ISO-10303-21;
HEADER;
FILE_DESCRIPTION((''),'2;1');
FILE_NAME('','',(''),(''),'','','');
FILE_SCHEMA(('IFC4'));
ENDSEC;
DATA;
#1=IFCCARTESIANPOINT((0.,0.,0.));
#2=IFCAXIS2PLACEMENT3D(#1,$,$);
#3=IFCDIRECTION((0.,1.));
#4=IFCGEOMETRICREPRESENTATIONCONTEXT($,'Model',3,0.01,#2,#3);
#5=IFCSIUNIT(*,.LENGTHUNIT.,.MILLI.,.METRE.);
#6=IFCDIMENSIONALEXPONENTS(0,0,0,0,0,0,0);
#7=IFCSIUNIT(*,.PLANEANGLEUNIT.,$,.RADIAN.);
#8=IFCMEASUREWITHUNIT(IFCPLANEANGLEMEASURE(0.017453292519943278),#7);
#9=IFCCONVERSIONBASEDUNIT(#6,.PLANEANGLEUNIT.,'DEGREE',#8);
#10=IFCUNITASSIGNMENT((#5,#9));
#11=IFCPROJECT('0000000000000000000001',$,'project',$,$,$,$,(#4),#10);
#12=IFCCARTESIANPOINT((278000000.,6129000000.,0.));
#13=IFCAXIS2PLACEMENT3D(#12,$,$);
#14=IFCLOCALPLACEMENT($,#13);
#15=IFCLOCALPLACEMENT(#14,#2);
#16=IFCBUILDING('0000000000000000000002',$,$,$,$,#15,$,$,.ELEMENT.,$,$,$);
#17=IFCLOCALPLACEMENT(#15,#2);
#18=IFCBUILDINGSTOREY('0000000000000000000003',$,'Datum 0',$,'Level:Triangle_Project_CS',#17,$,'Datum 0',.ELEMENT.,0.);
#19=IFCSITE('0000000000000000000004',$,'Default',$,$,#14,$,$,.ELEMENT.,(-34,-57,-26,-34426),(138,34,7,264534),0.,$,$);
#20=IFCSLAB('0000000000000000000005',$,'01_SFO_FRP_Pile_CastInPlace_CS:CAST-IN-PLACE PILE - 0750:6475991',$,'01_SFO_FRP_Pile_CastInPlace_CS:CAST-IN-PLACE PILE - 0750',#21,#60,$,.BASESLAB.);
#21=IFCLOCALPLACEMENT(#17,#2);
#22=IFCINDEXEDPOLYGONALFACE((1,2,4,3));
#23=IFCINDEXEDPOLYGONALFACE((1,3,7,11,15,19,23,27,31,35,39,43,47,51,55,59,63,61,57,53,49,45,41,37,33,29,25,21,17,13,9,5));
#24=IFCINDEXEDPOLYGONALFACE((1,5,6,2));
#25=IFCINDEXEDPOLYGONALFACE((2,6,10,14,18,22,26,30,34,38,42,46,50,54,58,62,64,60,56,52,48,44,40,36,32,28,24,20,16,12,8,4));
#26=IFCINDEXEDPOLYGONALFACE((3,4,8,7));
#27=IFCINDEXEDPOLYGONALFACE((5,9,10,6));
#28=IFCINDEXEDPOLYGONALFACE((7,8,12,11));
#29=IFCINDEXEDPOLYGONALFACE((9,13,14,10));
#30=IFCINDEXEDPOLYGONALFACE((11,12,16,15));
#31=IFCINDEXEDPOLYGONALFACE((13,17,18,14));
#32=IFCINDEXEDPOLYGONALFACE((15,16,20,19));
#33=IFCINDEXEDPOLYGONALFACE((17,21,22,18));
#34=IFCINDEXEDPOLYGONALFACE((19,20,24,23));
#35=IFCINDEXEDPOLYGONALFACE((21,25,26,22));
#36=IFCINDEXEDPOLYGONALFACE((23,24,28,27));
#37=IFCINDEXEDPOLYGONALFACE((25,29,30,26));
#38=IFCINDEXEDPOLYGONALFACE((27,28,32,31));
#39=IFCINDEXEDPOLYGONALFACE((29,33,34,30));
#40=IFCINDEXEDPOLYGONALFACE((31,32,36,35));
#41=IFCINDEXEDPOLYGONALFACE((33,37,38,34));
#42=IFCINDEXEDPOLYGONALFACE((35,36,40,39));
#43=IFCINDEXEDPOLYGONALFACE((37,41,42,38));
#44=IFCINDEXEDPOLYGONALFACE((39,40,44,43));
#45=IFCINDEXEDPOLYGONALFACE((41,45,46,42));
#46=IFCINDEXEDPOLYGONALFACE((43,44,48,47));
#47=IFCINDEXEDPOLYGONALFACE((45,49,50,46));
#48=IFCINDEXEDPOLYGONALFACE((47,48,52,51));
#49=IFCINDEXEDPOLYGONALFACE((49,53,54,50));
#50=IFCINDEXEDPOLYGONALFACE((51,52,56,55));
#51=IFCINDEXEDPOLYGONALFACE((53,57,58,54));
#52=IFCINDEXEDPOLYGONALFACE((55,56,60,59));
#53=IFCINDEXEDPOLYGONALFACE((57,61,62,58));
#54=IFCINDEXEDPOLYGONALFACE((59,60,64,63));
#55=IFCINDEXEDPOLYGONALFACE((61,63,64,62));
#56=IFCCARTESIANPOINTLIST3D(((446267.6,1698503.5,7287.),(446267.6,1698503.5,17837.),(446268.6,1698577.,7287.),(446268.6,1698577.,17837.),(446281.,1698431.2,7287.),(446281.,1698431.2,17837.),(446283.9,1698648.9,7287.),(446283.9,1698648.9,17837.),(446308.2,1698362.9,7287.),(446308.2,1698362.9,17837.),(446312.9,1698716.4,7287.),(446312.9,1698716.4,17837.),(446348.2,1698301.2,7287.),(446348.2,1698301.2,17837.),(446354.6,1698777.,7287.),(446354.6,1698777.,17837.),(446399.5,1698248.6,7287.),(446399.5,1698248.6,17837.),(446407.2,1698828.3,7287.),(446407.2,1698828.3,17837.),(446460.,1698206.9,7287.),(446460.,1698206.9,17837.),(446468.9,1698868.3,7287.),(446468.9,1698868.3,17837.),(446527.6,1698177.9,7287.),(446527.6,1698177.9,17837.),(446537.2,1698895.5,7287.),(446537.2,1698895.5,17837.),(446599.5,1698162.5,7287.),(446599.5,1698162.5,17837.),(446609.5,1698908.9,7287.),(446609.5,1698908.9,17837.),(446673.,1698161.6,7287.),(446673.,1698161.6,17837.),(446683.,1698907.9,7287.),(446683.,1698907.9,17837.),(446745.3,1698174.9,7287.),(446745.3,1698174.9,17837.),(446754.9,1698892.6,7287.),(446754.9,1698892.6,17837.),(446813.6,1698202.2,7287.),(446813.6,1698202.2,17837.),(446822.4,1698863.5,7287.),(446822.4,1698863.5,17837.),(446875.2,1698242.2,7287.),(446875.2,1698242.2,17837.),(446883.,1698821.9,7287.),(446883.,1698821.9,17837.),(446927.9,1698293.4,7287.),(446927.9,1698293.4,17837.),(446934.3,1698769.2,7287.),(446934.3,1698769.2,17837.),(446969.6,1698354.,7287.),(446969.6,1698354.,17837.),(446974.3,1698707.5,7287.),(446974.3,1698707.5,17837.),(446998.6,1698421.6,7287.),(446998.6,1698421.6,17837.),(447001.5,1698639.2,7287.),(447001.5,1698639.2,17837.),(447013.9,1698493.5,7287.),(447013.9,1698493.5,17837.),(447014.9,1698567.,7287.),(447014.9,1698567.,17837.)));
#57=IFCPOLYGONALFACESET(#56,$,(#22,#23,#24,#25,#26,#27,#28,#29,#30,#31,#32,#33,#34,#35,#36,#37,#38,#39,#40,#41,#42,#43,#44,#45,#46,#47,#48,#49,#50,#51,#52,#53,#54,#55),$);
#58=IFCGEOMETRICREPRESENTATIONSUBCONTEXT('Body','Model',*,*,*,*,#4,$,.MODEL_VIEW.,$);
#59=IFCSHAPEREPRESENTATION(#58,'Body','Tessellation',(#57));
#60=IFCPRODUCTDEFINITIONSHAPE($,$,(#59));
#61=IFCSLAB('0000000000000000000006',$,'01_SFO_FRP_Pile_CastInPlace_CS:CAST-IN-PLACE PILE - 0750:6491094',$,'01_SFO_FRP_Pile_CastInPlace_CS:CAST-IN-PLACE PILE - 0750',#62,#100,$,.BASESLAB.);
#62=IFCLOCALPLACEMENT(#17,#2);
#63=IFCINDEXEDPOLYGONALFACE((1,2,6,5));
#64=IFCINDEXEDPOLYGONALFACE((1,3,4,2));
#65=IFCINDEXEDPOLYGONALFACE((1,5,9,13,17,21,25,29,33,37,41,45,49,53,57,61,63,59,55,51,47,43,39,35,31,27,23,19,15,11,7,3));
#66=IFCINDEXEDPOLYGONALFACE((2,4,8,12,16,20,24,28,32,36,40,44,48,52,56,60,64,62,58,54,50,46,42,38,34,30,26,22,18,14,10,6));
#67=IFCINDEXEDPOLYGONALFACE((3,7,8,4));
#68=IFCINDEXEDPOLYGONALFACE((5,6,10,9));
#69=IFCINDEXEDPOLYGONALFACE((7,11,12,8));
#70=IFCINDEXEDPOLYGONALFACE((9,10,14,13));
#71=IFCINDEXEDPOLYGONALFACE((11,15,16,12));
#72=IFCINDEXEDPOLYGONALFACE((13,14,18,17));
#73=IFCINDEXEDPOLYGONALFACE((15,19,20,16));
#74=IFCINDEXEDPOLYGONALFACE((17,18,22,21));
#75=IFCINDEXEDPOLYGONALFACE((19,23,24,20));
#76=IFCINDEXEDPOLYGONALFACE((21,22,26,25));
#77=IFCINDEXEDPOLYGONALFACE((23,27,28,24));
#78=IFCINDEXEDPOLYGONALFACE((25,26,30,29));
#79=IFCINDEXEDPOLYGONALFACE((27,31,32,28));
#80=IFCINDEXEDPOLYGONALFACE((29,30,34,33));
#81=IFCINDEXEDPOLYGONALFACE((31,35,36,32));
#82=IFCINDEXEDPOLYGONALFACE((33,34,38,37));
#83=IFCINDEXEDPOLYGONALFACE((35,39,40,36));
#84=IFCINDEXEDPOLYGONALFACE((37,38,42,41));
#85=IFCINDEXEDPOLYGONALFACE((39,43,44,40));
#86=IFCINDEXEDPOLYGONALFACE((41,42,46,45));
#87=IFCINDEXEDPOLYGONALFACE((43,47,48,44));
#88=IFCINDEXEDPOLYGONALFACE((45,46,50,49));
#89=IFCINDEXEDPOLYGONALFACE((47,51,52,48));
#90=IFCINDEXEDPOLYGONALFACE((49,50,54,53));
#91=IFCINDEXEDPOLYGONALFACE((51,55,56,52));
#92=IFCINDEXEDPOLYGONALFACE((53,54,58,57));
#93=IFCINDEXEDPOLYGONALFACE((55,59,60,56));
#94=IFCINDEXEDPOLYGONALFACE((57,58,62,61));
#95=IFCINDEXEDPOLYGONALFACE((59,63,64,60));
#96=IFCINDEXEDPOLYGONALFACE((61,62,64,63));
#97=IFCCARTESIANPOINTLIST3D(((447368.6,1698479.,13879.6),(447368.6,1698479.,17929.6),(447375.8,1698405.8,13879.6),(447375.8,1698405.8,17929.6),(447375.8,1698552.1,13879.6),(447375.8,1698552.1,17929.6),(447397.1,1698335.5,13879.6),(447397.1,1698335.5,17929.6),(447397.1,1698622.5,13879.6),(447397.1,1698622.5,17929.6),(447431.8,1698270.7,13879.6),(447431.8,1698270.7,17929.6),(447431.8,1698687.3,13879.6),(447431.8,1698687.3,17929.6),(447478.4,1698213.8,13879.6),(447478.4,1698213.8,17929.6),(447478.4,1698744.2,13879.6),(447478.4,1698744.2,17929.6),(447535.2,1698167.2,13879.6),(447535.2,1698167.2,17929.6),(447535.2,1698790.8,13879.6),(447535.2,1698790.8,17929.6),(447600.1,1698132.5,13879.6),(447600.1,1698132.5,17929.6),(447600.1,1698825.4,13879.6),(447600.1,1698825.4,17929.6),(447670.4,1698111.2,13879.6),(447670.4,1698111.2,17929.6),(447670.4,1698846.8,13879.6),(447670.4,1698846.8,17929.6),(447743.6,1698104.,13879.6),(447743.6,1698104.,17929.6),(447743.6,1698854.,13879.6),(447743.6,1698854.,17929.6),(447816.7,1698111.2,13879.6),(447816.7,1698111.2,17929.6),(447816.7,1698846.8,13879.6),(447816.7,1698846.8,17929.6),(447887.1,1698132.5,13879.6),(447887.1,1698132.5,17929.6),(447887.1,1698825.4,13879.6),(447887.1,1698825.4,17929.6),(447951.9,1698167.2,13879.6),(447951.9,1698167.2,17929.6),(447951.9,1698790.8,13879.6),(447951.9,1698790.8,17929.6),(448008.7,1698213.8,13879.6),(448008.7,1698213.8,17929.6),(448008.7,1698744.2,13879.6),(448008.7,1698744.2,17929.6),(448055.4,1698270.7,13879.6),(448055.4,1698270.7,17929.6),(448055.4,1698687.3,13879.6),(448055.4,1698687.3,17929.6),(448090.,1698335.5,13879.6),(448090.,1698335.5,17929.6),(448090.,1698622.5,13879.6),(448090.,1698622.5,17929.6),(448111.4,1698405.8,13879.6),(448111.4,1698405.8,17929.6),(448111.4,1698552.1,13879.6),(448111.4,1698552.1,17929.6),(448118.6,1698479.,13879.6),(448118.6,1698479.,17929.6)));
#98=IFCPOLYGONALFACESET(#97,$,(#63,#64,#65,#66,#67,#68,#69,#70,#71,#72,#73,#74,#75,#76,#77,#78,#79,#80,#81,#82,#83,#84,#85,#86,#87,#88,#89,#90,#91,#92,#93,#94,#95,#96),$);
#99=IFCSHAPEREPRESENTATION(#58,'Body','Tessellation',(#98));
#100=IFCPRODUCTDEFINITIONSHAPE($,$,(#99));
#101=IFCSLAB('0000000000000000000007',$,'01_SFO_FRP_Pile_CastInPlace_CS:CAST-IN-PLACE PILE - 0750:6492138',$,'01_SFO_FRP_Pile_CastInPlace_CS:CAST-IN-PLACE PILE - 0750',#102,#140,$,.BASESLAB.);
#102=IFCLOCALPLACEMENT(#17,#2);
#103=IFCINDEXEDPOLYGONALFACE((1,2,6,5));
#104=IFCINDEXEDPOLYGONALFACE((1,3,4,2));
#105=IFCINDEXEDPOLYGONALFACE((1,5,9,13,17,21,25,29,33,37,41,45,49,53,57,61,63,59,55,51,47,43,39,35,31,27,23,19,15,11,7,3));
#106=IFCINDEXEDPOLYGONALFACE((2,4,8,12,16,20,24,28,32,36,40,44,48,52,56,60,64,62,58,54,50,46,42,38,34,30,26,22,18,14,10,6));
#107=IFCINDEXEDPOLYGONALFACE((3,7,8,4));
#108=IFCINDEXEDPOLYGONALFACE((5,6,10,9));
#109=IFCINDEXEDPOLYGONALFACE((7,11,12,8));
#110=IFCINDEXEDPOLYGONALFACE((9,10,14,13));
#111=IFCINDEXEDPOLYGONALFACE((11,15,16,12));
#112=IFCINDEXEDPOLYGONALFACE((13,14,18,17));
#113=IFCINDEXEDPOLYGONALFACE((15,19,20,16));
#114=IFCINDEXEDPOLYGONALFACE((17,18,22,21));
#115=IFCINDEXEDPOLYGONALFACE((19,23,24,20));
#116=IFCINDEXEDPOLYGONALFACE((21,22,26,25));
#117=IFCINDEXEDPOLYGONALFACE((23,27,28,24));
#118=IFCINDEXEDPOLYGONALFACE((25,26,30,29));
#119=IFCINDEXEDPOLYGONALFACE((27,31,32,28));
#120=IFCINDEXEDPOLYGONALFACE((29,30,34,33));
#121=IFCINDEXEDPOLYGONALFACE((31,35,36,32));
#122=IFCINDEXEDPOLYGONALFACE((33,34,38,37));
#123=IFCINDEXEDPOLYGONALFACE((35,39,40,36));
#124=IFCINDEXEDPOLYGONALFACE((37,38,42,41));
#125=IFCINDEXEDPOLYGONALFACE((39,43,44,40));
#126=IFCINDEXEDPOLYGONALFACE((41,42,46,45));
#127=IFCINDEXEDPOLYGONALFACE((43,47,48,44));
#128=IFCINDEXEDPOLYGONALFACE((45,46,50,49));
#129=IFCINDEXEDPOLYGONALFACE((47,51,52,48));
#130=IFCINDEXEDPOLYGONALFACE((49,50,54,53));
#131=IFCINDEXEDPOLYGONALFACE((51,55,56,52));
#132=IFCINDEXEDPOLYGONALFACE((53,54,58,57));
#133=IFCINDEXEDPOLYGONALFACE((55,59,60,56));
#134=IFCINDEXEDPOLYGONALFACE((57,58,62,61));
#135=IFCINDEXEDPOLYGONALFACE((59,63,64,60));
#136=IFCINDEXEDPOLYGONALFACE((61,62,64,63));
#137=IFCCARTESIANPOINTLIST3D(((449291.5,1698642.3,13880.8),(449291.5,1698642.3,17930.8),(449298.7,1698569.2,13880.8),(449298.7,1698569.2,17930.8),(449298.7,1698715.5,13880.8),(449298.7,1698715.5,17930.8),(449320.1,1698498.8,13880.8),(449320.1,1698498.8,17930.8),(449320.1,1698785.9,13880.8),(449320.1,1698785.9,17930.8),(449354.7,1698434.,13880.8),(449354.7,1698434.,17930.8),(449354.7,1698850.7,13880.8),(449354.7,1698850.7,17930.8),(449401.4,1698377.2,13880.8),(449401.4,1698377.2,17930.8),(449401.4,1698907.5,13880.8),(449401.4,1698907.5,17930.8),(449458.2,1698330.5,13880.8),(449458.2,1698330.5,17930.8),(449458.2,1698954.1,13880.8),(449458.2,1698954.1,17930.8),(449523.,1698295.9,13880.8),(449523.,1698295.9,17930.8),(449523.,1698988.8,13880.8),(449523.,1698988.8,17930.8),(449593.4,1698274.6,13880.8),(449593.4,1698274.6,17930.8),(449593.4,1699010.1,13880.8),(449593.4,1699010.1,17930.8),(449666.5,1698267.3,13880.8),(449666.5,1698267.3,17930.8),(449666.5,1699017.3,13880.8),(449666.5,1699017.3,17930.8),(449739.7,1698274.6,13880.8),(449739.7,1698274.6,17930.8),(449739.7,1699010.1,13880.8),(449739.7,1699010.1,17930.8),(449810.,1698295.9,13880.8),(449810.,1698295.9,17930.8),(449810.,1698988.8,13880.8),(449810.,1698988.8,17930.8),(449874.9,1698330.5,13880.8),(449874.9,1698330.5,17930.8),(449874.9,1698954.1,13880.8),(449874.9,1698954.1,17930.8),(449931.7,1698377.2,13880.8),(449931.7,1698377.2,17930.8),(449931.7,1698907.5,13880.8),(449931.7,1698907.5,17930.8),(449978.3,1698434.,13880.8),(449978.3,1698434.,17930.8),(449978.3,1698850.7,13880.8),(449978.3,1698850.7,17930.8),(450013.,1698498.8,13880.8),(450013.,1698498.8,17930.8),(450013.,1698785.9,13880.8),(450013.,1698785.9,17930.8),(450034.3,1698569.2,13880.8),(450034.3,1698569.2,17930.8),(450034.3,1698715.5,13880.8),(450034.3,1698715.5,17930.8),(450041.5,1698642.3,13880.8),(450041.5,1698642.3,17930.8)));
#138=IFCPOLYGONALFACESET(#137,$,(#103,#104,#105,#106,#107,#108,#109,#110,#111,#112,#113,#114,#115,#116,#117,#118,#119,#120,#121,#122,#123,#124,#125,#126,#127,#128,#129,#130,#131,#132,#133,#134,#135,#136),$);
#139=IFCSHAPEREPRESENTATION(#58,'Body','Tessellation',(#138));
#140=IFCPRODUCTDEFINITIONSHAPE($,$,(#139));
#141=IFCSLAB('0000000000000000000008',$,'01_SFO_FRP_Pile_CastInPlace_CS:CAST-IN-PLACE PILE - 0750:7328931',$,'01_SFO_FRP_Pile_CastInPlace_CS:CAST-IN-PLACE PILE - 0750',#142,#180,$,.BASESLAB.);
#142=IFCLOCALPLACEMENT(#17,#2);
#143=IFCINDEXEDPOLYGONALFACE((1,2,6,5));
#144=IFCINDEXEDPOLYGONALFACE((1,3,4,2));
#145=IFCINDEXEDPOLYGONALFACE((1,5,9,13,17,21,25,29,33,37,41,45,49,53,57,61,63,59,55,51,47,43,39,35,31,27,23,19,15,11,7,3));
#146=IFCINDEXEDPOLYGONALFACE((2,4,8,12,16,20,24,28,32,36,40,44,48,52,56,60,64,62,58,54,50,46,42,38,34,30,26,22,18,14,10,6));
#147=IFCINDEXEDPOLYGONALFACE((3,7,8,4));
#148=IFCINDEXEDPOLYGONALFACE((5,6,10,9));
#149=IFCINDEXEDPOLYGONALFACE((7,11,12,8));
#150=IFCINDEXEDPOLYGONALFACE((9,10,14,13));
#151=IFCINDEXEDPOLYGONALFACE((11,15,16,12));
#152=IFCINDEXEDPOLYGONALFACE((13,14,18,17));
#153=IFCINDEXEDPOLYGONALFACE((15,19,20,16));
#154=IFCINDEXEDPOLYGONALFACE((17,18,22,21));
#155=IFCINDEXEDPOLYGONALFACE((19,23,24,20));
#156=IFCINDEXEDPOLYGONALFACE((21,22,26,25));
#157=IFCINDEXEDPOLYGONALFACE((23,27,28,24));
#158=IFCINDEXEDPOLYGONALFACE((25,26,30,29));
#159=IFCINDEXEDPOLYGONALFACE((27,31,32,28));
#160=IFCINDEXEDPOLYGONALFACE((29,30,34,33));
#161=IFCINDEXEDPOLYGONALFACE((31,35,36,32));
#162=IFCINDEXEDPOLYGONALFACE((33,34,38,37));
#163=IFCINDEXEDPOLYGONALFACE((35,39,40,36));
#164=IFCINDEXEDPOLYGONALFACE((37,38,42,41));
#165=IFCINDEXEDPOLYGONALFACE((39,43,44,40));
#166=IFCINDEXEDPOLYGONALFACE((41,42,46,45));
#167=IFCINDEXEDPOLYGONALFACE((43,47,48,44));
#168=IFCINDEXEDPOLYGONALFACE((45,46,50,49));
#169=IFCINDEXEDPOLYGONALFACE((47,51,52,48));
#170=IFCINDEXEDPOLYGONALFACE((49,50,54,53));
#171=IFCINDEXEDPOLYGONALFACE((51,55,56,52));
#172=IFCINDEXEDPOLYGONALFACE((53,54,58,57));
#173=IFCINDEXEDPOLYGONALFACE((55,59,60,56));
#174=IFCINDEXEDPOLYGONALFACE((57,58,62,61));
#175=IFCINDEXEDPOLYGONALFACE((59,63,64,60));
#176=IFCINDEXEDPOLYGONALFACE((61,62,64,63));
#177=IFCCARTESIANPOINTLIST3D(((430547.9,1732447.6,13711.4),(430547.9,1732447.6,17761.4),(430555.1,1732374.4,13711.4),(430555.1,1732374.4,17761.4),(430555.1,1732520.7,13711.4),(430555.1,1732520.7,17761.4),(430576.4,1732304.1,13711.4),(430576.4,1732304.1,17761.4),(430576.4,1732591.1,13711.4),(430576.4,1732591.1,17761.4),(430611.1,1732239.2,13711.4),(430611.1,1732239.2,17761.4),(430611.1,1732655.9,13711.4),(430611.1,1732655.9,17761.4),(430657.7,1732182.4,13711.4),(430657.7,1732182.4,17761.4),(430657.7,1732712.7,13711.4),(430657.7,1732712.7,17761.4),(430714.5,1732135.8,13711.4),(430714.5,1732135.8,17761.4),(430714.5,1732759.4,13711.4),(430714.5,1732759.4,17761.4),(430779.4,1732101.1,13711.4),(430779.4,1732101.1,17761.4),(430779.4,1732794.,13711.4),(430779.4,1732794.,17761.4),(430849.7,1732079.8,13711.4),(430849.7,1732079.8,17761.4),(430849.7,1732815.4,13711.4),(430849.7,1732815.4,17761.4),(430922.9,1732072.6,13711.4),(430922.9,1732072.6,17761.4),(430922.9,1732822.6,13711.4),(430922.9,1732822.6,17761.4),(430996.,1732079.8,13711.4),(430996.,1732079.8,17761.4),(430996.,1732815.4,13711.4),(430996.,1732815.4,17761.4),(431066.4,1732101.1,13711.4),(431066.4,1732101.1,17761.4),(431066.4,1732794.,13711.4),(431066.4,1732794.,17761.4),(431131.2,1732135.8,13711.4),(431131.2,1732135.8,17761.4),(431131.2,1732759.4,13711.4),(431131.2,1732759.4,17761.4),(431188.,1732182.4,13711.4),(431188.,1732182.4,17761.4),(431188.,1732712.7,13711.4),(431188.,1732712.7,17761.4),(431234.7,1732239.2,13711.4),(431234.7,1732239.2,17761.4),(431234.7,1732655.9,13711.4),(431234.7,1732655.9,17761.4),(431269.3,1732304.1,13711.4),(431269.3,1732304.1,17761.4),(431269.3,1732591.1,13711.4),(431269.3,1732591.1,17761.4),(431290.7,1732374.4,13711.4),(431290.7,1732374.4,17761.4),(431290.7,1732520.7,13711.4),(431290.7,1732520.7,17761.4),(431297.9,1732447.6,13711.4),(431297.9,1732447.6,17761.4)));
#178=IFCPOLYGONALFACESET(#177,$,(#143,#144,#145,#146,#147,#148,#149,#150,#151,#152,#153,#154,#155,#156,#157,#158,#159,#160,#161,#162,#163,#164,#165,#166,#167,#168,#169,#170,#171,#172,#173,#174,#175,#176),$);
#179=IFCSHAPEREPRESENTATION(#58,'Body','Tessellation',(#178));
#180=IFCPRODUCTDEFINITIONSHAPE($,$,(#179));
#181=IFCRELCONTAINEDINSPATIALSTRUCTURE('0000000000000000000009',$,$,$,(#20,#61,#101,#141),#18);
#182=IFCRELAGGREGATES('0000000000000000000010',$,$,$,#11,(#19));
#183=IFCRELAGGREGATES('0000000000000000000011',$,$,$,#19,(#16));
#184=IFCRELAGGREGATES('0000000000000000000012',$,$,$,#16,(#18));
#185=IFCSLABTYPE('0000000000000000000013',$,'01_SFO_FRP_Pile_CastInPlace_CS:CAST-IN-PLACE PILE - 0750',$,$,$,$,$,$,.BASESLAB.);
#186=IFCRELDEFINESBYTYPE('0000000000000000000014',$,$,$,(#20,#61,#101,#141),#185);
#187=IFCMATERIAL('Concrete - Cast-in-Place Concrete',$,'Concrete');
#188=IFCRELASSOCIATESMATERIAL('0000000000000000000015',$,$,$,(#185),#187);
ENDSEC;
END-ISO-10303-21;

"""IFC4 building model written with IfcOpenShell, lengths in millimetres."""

from ifc_helpers import new_model, entity, si_unit, converted_unit, direction, frame, origin, place, context, subcontext, project, spatial, arc, indexed_curve, outline, extrude, material, type_object, element, save


model = new_model("IFC4")

# Units and contexts
model_context = context("Model", 3, precision=0.01, world=origin(), true_north=direction((0.0, 1.0)))
body_context = subcontext(model_context, "Body", "Model", "MODEL_VIEW")
ifc_project = project(units=[si_unit("LENGTHUNIT", "METRE", prefix="MILLI"), converted_unit("PLANEANGLEUNIT", "DEGREE", entity("IfcPlaneAngleMeasure", 0.017453292519943278), si_unit("PLANEANGLEUNIT", "RADIAN"), dimensions=[0, 0, 0, 0, 0, 0, 0])], contexts=[model_context])

# Site, building, storey
site_placement = place(None, frame((278000000.0, 6129000000.0, 0.0)))
site = spatial("IfcSite", under=ifc_project, at=site_placement, Name="Default", CompositionType="ELEMENT", RefLatitude=(-34, -57, -26, -34426), RefLongitude=(138, 34, 7, 264534), RefElevation=0.0)
building_placement = place(site_placement, origin())
building = spatial("IfcBuilding", under=site, at=building_placement, CompositionType="ELEMENT")
storey_placement = place(building_placement, frame((0.0, 0.0, 0.0)))
storey = spatial("IfcBuildingStorey", under=building, at=storey_placement, Name="Datum 0", ObjectType="Level:Triangle_Project_CS", LongName="Datum 0", CompositionType="ELEMENT", Elevation=0.0)

# Slabs
ifc_material_1 = material(Name="Concrete - Cast-in-Place Concrete", Category="Concrete")
slab_type_1 = type_object("IfcSlabType", Name="01_SFO_FRP_Pile_CastInPlace_CS:CAST-IN-PLACE PILE - 0750", PredefinedType="BASESLAB", material=ifc_material_1)
slab_1_placement = place(storey_placement, origin())
element("IfcSlab", 1, at=slab_1_placement, inside=storey, type_object=slab_type_1, Name="01_SFO_FRP_Pile_CastInPlace_CS:CAST-IN-PLACE PILE - 0750:6475991", ObjectType="01_SFO_FRP_Pile_CastInPlace_CS:CAST-IN-PLACE PILE - 0750", PredefinedType="BASESLAB", context=body_context, shape_type="SweptSolid", body=[
    extrude(outline(indexed_curve([(-375.0, 0.0), (0.0, -375.0), (375.0, 0.0), (0.0, 375.0)], segments=[arc(1, 2, 3), arc(3, 4, 1)], self_intersect=False)), frame((446641.2, 1698535.2, 7287.0), z_axis=(0.0, 0.0, 1.0), x_axis=(0.996411, 0.084646, 0.0)), (0.0, 0.0, 1.0), 10550.0),
])
slab_2_placement = place(storey_placement, origin())
element("IfcSlab", 2, at=slab_2_placement, inside=storey, type_object=slab_type_1, Name="01_SFO_FRP_Pile_CastInPlace_CS:CAST-IN-PLACE PILE - 0750:6491094", ObjectType="01_SFO_FRP_Pile_CastInPlace_CS:CAST-IN-PLACE PILE - 0750", PredefinedType="BASESLAB", context=body_context, shape_type="SweptSolid", body=[
    extrude(outline(indexed_curve([(-375.0, 0.0), (0.0, -375.0), (375.0, 0.0), (0.0, 375.0)], segments=[arc(1, 2, 3), arc(3, 4, 1)], self_intersect=False)), frame((447743.6, 1698479.0, 13879.6), z_axis=(0.0, 0.0, 1.0), x_axis=(0.0, -1.0, 0.0)), (0.0, 0.0, 1.0), 4050.0),
])
slab_3_placement = place(storey_placement, origin())
element("IfcSlab", 3, at=slab_3_placement, inside=storey, type_object=slab_type_1, Name="01_SFO_FRP_Pile_CastInPlace_CS:CAST-IN-PLACE PILE - 0750:6492138", ObjectType="01_SFO_FRP_Pile_CastInPlace_CS:CAST-IN-PLACE PILE - 0750", PredefinedType="BASESLAB", context=body_context, shape_type="SweptSolid", body=[
    extrude(outline(indexed_curve([(-375.0, 0.0), (0.0, -375.0), (375.0, 0.0), (0.0, 375.0)], segments=[arc(1, 2, 3), arc(3, 4, 1)], self_intersect=False)), frame((449666.5, 1698642.3, 13880.8), z_axis=(0.0, 0.0, 1.0), x_axis=(0.0, -1.0, 0.0)), (0.0, 0.0, 1.0), 4050.0),
])
slab_4_placement = place(storey_placement, origin())
element("IfcSlab", 4, at=slab_4_placement, inside=storey, type_object=slab_type_1, Name="01_SFO_FRP_Pile_CastInPlace_CS:CAST-IN-PLACE PILE - 0750:7328931", ObjectType="01_SFO_FRP_Pile_CastInPlace_CS:CAST-IN-PLACE PILE - 0750", PredefinedType="BASESLAB", context=body_context, shape_type="SweptSolid", body=[
    extrude(outline(indexed_curve([(-375.0, 0.0), (0.0, -375.0), (375.0, 0.0), (0.0, 375.0)], segments=[arc(1, 2, 3), arc(3, 4, 1)], self_intersect=False)), frame((430922.9, 1732447.6, 13711.4), z_axis=(0.0, 0.0, 1.0), x_axis=(0.0, -1.0, 0.0)), (0.0, 0.0, 1.0), 4050.0),
])

save(model, "model.ifc")
